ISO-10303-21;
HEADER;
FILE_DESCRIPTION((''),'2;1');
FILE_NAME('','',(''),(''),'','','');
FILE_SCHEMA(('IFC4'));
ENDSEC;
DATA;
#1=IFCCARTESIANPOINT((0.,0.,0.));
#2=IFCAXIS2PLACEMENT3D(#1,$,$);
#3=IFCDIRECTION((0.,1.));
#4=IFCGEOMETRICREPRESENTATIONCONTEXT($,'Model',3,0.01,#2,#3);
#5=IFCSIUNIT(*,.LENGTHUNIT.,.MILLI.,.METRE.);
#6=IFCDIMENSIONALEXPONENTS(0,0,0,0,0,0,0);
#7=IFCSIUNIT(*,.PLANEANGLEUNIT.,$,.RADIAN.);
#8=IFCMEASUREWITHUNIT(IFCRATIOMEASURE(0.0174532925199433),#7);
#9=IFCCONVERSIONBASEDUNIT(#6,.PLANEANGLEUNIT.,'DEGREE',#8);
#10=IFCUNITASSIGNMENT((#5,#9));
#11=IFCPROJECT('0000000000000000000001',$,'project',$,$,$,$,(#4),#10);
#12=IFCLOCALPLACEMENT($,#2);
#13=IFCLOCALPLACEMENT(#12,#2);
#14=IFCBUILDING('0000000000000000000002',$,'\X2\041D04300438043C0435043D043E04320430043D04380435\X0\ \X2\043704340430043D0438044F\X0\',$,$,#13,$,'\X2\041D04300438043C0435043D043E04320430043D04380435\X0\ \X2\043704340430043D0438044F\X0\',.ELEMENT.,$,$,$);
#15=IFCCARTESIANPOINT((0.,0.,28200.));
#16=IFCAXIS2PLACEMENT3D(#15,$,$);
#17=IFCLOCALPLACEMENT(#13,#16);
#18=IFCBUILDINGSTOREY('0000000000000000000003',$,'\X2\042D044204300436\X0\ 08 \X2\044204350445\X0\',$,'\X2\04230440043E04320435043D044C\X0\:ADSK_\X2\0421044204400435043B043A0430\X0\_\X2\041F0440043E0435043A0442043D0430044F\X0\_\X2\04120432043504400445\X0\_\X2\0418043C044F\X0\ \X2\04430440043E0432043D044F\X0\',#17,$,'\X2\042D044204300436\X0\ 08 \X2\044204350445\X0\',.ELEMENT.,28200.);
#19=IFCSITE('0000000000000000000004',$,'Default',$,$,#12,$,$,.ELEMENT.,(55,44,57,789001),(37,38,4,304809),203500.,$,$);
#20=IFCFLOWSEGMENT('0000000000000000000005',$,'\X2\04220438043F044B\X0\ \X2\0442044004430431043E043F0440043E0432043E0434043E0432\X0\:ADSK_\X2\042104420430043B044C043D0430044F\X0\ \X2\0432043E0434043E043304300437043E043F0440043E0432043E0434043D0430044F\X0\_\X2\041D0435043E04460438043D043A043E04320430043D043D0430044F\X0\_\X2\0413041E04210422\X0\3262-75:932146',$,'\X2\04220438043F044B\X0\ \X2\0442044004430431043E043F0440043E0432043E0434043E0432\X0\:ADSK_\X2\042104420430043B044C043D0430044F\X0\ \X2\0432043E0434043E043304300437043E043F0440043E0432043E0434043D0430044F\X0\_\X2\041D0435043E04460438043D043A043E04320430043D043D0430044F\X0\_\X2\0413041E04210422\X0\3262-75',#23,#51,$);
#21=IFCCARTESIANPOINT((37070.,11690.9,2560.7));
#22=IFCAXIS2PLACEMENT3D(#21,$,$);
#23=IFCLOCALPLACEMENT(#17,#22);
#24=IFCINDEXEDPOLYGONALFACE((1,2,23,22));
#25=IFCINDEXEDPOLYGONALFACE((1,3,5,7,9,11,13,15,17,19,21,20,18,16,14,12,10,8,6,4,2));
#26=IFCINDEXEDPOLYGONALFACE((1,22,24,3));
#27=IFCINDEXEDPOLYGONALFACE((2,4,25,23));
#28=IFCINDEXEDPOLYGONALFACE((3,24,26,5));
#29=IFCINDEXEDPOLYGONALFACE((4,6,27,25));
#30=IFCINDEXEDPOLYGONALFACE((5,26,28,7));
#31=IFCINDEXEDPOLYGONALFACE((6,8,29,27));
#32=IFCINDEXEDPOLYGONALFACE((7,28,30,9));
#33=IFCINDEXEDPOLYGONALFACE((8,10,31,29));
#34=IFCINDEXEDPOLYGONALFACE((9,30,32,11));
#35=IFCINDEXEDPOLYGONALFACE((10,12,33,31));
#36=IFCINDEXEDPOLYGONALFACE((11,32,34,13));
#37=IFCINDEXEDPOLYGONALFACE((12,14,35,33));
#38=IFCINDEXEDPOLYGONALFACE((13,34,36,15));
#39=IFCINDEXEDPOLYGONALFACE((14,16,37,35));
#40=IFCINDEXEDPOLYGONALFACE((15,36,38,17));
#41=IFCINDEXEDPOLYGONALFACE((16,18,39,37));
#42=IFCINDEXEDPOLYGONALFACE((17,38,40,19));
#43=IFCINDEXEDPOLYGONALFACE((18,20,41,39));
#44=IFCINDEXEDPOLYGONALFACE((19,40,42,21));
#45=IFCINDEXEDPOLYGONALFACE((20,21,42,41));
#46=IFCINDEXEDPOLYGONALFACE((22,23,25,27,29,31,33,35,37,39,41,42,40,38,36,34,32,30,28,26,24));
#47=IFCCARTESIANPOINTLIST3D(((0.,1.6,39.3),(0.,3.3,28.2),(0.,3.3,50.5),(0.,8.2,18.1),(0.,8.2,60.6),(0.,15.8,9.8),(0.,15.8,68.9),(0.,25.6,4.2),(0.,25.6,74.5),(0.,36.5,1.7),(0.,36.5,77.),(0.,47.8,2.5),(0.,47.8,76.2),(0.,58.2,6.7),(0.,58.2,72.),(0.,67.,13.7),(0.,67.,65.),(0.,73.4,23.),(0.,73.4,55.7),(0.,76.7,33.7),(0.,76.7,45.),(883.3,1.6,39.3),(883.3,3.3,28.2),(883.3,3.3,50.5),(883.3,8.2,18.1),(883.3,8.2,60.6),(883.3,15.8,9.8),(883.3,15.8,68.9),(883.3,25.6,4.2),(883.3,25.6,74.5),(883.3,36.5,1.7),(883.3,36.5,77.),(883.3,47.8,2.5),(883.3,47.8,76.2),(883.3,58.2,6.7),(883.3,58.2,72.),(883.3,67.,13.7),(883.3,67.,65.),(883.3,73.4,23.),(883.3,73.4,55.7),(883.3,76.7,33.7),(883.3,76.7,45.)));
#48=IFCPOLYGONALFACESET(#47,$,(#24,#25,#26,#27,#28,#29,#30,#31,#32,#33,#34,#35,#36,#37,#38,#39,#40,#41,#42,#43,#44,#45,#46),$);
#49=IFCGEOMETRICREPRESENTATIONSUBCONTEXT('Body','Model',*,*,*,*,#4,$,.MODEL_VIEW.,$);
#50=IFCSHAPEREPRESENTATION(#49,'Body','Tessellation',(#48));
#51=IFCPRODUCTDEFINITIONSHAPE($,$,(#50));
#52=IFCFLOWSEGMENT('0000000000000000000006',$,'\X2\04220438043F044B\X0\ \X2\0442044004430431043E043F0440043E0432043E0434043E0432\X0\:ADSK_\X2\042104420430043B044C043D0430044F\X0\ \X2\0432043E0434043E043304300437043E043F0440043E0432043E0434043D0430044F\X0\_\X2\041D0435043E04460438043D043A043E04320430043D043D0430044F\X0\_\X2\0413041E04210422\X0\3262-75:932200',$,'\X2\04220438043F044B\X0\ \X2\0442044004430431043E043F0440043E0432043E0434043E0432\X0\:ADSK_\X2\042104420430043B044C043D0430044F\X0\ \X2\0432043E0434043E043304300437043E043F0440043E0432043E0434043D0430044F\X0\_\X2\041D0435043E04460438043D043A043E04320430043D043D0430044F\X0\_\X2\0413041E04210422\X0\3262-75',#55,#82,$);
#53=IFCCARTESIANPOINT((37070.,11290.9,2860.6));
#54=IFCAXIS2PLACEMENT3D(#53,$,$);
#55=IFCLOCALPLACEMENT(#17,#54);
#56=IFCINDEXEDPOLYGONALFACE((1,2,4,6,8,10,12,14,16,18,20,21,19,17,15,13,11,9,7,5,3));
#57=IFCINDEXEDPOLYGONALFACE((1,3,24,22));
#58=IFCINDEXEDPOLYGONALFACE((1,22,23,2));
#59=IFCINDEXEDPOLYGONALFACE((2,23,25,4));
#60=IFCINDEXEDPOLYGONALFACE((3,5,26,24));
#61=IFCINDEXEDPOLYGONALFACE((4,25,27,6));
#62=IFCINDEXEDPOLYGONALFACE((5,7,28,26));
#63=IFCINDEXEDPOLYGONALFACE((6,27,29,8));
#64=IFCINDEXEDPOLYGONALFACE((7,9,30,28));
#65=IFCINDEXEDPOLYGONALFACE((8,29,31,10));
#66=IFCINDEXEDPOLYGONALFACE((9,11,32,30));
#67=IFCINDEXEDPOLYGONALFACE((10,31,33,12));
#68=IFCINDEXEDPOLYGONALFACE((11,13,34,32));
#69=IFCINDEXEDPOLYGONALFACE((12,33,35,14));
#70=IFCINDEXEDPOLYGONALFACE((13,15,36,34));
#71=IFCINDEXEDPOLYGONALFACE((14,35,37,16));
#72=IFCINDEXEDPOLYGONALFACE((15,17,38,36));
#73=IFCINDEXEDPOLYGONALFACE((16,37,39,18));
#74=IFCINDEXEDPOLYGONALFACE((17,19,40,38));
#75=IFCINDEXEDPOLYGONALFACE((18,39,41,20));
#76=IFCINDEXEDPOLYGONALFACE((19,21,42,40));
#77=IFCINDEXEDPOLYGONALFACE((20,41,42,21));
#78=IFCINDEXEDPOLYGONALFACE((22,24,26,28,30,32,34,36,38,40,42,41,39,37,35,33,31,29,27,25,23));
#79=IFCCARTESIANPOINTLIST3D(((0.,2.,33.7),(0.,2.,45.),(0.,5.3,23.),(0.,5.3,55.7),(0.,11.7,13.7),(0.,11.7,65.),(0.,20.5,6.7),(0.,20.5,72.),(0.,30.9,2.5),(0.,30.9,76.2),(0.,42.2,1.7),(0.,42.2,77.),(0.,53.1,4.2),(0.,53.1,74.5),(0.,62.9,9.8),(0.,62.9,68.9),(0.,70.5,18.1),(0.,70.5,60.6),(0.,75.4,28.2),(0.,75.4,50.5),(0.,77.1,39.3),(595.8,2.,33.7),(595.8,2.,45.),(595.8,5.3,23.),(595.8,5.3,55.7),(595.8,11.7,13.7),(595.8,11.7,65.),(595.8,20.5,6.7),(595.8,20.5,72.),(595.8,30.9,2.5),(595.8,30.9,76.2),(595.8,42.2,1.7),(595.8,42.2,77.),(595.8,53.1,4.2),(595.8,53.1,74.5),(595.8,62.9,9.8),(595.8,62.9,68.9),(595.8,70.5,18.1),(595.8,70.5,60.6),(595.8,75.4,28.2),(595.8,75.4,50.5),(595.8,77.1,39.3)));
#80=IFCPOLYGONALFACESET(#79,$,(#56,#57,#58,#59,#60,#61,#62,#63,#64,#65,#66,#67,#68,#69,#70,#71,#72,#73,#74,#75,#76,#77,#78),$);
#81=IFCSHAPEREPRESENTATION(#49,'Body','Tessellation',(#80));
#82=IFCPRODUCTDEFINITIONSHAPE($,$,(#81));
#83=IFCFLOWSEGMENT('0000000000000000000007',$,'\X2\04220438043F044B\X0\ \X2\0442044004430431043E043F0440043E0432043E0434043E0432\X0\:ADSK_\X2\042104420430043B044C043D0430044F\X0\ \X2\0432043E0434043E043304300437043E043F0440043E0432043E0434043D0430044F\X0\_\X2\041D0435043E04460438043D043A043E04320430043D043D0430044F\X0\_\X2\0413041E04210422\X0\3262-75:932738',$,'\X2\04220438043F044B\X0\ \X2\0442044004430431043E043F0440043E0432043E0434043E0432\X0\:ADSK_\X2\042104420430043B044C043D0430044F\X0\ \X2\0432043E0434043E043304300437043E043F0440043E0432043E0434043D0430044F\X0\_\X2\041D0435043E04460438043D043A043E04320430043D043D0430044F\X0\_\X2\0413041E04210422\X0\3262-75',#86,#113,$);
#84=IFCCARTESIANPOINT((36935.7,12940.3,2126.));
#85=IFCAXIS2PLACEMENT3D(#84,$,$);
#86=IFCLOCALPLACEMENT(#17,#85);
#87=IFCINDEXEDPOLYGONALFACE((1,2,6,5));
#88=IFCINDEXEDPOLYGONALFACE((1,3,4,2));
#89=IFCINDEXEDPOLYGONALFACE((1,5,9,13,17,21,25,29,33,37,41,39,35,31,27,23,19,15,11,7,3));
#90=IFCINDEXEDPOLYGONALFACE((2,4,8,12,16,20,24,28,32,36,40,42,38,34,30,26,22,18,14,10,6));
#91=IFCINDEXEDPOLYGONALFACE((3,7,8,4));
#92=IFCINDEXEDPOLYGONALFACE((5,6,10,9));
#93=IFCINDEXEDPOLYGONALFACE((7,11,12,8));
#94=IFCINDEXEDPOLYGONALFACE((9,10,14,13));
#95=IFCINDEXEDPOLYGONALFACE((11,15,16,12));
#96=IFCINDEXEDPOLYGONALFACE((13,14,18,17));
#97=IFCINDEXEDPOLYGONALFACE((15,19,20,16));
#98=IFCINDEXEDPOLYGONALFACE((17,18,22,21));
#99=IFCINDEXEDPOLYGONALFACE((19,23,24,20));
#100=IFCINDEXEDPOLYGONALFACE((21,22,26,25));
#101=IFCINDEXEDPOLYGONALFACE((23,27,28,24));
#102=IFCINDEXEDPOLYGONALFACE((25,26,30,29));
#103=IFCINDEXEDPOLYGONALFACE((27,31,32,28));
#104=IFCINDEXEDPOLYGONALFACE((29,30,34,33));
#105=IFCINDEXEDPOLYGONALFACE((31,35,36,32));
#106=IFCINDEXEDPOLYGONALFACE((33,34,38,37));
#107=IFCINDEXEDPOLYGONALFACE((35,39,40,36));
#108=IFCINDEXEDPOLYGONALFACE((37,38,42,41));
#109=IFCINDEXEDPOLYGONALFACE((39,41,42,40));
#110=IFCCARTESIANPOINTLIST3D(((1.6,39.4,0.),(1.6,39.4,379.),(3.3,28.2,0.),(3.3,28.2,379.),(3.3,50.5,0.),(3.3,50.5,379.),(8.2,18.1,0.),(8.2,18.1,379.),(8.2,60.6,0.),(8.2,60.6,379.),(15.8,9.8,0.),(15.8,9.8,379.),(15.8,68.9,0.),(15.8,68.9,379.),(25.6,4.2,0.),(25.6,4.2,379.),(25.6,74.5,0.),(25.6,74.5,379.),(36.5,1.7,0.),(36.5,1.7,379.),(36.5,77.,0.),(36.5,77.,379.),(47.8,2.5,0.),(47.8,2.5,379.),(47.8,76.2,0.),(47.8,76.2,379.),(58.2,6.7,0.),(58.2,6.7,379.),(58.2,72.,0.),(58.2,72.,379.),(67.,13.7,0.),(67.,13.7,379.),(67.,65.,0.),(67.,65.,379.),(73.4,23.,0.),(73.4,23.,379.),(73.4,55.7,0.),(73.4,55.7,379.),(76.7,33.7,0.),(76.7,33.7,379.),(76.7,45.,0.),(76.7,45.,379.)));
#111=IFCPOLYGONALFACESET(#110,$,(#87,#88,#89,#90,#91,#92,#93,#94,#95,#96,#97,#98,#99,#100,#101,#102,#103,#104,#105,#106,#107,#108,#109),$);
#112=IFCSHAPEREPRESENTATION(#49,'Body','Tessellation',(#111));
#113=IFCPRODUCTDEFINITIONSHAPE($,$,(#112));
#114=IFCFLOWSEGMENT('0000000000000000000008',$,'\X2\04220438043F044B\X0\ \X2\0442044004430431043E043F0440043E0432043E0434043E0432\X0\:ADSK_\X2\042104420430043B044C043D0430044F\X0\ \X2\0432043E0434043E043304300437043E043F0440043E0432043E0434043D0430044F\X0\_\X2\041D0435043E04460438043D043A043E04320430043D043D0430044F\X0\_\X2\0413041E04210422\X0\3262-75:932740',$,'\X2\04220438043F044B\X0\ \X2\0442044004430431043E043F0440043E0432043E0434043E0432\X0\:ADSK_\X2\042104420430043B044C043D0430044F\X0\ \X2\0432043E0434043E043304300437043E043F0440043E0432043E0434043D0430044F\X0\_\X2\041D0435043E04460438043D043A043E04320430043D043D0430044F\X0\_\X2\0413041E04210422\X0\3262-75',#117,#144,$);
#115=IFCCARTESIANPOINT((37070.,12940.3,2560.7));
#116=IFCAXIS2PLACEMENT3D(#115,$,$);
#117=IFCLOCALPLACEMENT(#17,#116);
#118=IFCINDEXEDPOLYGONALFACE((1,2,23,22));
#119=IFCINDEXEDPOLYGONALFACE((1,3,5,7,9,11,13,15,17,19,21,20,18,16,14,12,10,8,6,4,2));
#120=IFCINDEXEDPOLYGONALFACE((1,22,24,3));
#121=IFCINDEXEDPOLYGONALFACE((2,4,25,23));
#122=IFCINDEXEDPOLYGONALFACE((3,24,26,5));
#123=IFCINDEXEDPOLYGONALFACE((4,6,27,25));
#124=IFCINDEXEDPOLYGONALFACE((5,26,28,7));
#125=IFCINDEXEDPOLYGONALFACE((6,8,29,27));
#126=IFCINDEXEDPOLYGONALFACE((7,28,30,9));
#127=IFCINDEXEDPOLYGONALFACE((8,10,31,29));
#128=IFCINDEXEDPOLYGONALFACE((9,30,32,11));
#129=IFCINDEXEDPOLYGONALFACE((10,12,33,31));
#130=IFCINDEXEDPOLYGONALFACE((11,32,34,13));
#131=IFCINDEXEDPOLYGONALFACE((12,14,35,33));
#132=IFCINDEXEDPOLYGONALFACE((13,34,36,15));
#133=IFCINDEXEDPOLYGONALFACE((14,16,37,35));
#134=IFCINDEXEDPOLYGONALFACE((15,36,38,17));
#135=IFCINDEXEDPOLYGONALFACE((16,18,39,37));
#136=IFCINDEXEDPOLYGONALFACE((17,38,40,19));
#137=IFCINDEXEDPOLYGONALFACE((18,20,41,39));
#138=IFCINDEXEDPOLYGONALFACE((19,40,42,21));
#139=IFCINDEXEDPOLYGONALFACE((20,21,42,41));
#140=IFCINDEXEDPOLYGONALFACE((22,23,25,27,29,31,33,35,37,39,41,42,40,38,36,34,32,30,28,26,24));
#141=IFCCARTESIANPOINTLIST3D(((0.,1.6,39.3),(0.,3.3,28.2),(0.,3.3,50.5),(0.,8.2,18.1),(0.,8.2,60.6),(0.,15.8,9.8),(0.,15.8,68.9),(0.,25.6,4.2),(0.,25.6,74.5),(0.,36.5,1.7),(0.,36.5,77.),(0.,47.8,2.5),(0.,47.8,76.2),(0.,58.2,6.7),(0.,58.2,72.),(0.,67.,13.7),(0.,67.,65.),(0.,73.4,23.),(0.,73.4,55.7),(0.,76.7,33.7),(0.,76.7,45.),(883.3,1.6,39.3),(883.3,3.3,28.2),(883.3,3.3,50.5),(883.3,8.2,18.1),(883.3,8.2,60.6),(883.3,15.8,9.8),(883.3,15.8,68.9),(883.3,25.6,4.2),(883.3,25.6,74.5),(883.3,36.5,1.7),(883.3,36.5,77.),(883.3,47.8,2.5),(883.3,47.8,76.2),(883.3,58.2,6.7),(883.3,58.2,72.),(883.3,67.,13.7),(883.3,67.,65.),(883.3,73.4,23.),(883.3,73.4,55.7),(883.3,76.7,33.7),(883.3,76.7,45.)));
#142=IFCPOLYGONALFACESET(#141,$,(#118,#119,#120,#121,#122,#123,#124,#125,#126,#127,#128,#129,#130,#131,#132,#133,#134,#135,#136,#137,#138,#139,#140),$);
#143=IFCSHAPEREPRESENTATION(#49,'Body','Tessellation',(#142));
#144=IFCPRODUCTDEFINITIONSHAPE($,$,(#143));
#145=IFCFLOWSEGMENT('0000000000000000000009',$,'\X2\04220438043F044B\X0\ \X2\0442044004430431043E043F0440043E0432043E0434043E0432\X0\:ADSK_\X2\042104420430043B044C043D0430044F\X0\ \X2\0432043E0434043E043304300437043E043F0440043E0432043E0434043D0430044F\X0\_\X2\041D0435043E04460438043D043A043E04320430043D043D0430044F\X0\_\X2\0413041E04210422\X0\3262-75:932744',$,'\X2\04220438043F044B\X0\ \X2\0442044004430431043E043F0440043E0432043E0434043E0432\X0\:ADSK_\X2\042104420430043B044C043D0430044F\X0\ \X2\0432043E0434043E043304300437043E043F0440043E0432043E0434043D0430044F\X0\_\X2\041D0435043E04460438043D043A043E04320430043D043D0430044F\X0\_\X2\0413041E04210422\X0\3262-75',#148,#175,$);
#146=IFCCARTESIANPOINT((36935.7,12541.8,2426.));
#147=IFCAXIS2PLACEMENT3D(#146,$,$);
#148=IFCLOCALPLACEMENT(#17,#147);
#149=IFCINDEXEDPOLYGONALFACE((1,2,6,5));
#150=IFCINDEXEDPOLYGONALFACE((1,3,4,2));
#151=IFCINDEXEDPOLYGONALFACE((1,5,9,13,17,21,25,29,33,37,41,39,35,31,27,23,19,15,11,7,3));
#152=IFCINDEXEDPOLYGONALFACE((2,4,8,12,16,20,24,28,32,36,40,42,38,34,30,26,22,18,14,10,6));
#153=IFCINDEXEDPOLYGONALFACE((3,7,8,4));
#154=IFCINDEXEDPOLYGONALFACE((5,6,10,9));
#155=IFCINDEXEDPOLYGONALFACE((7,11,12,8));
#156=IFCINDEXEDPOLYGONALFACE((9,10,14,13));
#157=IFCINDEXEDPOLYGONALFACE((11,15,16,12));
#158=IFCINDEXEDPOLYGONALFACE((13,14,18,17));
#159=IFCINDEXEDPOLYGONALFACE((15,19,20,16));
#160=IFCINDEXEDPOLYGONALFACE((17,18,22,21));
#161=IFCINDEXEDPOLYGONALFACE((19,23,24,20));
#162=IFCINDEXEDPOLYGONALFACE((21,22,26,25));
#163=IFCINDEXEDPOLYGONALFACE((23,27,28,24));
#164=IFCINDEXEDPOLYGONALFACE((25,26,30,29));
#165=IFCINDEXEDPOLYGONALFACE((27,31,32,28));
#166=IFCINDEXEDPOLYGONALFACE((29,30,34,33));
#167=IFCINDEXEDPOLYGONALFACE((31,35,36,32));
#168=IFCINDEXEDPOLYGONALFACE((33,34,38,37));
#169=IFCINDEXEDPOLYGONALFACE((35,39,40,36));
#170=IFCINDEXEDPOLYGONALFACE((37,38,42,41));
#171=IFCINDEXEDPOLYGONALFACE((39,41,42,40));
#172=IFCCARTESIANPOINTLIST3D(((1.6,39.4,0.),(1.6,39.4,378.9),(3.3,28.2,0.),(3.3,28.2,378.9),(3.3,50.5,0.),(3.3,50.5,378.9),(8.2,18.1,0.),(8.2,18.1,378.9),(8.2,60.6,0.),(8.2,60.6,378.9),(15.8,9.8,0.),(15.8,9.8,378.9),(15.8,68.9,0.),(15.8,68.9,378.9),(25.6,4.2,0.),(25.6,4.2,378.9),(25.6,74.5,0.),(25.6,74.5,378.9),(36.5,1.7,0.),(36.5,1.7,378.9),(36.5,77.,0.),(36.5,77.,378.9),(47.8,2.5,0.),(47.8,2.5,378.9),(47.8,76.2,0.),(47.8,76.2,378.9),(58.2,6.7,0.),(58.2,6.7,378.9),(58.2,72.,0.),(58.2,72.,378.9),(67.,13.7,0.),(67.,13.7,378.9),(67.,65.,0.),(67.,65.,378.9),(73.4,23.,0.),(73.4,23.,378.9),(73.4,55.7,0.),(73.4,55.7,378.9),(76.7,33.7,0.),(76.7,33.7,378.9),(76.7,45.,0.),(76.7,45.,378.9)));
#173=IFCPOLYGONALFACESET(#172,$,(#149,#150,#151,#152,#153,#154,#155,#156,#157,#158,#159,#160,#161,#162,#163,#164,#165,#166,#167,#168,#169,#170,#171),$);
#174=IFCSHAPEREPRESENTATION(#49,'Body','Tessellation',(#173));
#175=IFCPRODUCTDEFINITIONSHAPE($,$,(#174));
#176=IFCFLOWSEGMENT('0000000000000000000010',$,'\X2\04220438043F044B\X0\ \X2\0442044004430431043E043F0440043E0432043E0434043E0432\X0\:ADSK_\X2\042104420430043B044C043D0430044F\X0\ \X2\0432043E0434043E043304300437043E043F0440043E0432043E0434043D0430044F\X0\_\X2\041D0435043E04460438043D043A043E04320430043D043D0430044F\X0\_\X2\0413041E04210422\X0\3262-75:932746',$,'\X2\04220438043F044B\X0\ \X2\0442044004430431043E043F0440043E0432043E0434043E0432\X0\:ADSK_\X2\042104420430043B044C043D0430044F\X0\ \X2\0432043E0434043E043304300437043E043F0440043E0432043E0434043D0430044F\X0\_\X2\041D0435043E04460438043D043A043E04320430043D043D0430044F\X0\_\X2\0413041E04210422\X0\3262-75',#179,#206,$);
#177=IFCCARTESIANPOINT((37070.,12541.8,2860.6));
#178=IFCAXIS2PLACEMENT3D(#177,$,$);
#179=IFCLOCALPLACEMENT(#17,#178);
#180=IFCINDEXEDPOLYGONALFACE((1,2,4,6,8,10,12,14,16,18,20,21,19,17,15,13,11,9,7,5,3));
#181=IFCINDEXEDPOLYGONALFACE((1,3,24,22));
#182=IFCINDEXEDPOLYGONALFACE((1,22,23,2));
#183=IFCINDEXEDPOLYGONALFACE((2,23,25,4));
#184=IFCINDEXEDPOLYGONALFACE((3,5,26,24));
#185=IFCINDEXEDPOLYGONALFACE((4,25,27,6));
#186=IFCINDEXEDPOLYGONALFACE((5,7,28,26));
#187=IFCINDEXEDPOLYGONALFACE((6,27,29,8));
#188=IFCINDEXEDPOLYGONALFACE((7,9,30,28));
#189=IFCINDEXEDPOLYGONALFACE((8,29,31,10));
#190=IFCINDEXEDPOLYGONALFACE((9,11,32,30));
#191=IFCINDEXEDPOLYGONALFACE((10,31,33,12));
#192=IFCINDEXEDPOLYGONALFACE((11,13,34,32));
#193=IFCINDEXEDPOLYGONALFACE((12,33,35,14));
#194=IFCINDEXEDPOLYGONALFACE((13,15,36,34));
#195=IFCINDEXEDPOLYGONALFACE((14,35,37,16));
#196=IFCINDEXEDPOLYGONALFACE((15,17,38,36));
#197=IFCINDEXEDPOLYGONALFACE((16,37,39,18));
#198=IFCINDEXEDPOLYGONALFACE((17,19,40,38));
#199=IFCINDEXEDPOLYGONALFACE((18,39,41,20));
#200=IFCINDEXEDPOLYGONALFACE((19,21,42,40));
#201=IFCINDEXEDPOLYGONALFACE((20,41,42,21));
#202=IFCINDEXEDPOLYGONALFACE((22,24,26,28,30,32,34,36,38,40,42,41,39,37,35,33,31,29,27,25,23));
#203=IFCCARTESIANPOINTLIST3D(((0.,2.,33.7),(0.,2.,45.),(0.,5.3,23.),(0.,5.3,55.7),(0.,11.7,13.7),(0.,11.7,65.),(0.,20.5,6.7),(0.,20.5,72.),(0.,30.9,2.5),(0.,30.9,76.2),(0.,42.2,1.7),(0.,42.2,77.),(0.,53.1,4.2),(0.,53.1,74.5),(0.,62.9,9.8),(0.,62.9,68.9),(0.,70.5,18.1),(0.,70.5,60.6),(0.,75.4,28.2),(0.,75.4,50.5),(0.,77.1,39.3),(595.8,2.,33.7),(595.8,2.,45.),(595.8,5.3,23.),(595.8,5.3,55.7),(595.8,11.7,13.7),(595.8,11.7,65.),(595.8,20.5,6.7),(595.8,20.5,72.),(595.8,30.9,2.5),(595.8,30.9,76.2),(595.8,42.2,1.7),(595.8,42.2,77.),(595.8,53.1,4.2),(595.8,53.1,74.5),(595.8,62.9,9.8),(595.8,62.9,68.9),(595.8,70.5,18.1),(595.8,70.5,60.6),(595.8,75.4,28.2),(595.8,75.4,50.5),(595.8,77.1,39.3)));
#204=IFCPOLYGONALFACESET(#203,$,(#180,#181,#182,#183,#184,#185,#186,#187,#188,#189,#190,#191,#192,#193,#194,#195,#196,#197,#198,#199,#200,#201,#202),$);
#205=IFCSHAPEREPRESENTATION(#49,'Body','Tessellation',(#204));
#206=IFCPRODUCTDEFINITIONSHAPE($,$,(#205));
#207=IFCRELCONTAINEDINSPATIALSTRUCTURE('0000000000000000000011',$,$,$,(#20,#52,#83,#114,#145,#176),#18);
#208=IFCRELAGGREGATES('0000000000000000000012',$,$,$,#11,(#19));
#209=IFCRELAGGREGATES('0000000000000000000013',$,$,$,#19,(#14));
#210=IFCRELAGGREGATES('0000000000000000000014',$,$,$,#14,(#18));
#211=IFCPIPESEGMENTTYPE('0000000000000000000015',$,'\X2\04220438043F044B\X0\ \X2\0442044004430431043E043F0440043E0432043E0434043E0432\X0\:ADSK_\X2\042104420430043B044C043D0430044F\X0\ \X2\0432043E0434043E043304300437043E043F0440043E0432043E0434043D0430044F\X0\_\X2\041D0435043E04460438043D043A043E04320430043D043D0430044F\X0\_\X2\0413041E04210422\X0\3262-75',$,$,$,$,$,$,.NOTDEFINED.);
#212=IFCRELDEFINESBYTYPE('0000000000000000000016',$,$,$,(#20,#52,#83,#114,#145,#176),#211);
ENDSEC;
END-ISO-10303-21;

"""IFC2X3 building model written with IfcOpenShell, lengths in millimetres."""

from ifc_helpers import new_model, entity, si_unit, converted_unit, direction, frame, origin, origin_2d_with_axis, place, context, subcontext, project, spatial, circle, extrude, type_object, element, save


model = new_model("IFC2X3")

# Units and contexts
model_context = context("Model", 3, precision=0.01, world=origin(), true_north=direction((0.0, 1.0)))
body_context = subcontext(model_context, "Body", "Model", "MODEL_VIEW")
ifc_project = project(units=[si_unit("LENGTHUNIT", "METRE", prefix="MILLI"), converted_unit("PLANEANGLEUNIT", "DEGREE", entity("IfcRatioMeasure", 0.0174532925199433), si_unit("PLANEANGLEUNIT", "RADIAN"), dimensions=[0, 0, 0, 0, 0, 0, 0])], contexts=[model_context])

# Site, building, storey
site_placement = place(None, origin())
site = spatial("IfcSite", under=ifc_project, at=site_placement, Name="Default", CompositionType="ELEMENT", RefLatitude=(55, 44, 57, 789001), RefLongitude=(37, 38, 4, 304809), RefElevation=203500.0)
building_placement = place(site_placement, origin())
building = spatial("IfcBuilding", under=site, at=building_placement, Name="Наименование здания", LongName="Наименование здания", CompositionType="ELEMENT")
storey_placement = place(building_placement, frame((0.0, 0.0, 28200.0)))
storey = spatial("IfcBuildingStorey", under=building, at=storey_placement, Name="Этаж 08 тех", ObjectType="Уровень:ADSK_Стрелка_Проектная_Вверх_Имя уровня", LongName="Этаж 08 тех", CompositionType="ELEMENT", Elevation=28200.0)

# Flow segments
pipe_segment_type_1 = type_object("IfcPipeSegmentType", Name="Типы трубопроводов:ADSK_Стальная водогазопроводная_Неоцинкованная_ГОСТ3262-75", PredefinedType="NOTDEFINED")
flow_segment_1_placement = place(storey_placement, frame((37070.0, 11690.9, 2560.7)))
element("IfcFlowSegment", 1, at=flow_segment_1_placement, inside=storey, type_object=pipe_segment_type_1, Name="Типы трубопроводов:ADSK_Стальная водогазопроводная_Неоцинкованная_ГОСТ3262-75:932146", ObjectType="Типы трубопроводов:ADSK_Стальная водогазопроводная_Неоцинкованная_ГОСТ3262-75", context=body_context, shape_type="SweptSolid", body=[
    extrude(circle(Radius=37.8, at=origin_2d_with_axis()), frame((0.0, 39.4, 39.4), z_axis=(1.0, 0.0, 0.0), x_axis=(0.0, -1.0, 0.0)), (0.0, 0.0, 1.0), 883.3),
])
flow_segment_2_placement = place(storey_placement, frame((37070.0, 11290.9, 2860.6)))
element("IfcFlowSegment", 2, at=flow_segment_2_placement, inside=storey, type_object=pipe_segment_type_1, Name="Типы трубопроводов:ADSK_Стальная водогазопроводная_Неоцинкованная_ГОСТ3262-75:932200", ObjectType="Типы трубопроводов:ADSK_Стальная водогазопроводная_Неоцинкованная_ГОСТ3262-75", context=body_context, shape_type="SweptSolid", body=[
    extrude(circle(Radius=37.8, at=origin_2d_with_axis()), frame((0.0, 39.4, 39.4), z_axis=(1.0, 0.0, 0.0), x_axis=(0.0, 1.0, 0.0)), (0.0, 0.0, 1.0), 595.8),
])
flow_segment_3_placement = place(storey_placement, frame((36935.7, 12940.3, 2126.0)))
element("IfcFlowSegment", 3, at=flow_segment_3_placement, inside=storey, type_object=pipe_segment_type_1, Name="Типы трубопроводов:ADSK_Стальная водогазопроводная_Неоцинкованная_ГОСТ3262-75:932738", ObjectType="Типы трубопроводов:ADSK_Стальная водогазопроводная_Неоцинкованная_ГОСТ3262-75", context=body_context, shape_type="SweptSolid", body=[
    extrude(circle(Radius=37.8, at=origin_2d_with_axis()), frame((39.4, 39.4, 0.0), z_axis=(0.0, 0.0, 1.0), x_axis=(-1.0, 0.0, 0.0)), (0.0, 0.0, 1.0), 379.0),
])
flow_segment_4_placement = place(storey_placement, frame((37070.0, 12940.3, 2560.7)))
element("IfcFlowSegment", 4, at=flow_segment_4_placement, inside=storey, type_object=pipe_segment_type_1, Name="Типы трубопроводов:ADSK_Стальная водогазопроводная_Неоцинкованная_ГОСТ3262-75:932740", ObjectType="Типы трубопроводов:ADSK_Стальная водогазопроводная_Неоцинкованная_ГОСТ3262-75", context=body_context, shape_type="SweptSolid", body=[
    extrude(circle(Radius=37.8, at=origin_2d_with_axis()), frame((0.0, 39.4, 39.4), z_axis=(1.0, 0.0, 0.0), x_axis=(0.0, -1.0, 0.0)), (0.0, 0.0, 1.0), 883.3),
])
flow_segment_5_placement = place(storey_placement, frame((36935.7, 12541.8, 2426.0)))
element("IfcFlowSegment", 5, at=flow_segment_5_placement, inside=storey, type_object=pipe_segment_type_1, Name="Типы трубопроводов:ADSK_Стальная водогазопроводная_Неоцинкованная_ГОСТ3262-75:932744", ObjectType="Типы трубопроводов:ADSK_Стальная водогазопроводная_Неоцинкованная_ГОСТ3262-75", context=body_context, shape_type="SweptSolid", body=[
    extrude(circle(Radius=37.8, at=origin_2d_with_axis()), frame((39.4, 39.4, 0.0), z_axis=(0.0, 0.0, 1.0), x_axis=(-1.0, 0.0, 0.0)), (0.0, 0.0, 1.0), 378.9),
])
flow_segment_6_placement = place(storey_placement, frame((37070.0, 12541.8, 2860.6)))
element("IfcFlowSegment", 6, at=flow_segment_6_placement, inside=storey, type_object=pipe_segment_type_1, Name="Типы трубопроводов:ADSK_Стальная водогазопроводная_Неоцинкованная_ГОСТ3262-75:932746", ObjectType="Типы трубопроводов:ADSK_Стальная водогазопроводная_Неоцинкованная_ГОСТ3262-75", context=body_context, shape_type="SweptSolid", body=[
    extrude(circle(Radius=37.8, at=origin_2d_with_axis()), frame((0.0, 39.4, 39.4), z_axis=(1.0, 0.0, 0.0), x_axis=(0.0, 1.0, 0.0)), (0.0, 0.0, 1.0), 595.8),
])

save(model, "model.ifc")
